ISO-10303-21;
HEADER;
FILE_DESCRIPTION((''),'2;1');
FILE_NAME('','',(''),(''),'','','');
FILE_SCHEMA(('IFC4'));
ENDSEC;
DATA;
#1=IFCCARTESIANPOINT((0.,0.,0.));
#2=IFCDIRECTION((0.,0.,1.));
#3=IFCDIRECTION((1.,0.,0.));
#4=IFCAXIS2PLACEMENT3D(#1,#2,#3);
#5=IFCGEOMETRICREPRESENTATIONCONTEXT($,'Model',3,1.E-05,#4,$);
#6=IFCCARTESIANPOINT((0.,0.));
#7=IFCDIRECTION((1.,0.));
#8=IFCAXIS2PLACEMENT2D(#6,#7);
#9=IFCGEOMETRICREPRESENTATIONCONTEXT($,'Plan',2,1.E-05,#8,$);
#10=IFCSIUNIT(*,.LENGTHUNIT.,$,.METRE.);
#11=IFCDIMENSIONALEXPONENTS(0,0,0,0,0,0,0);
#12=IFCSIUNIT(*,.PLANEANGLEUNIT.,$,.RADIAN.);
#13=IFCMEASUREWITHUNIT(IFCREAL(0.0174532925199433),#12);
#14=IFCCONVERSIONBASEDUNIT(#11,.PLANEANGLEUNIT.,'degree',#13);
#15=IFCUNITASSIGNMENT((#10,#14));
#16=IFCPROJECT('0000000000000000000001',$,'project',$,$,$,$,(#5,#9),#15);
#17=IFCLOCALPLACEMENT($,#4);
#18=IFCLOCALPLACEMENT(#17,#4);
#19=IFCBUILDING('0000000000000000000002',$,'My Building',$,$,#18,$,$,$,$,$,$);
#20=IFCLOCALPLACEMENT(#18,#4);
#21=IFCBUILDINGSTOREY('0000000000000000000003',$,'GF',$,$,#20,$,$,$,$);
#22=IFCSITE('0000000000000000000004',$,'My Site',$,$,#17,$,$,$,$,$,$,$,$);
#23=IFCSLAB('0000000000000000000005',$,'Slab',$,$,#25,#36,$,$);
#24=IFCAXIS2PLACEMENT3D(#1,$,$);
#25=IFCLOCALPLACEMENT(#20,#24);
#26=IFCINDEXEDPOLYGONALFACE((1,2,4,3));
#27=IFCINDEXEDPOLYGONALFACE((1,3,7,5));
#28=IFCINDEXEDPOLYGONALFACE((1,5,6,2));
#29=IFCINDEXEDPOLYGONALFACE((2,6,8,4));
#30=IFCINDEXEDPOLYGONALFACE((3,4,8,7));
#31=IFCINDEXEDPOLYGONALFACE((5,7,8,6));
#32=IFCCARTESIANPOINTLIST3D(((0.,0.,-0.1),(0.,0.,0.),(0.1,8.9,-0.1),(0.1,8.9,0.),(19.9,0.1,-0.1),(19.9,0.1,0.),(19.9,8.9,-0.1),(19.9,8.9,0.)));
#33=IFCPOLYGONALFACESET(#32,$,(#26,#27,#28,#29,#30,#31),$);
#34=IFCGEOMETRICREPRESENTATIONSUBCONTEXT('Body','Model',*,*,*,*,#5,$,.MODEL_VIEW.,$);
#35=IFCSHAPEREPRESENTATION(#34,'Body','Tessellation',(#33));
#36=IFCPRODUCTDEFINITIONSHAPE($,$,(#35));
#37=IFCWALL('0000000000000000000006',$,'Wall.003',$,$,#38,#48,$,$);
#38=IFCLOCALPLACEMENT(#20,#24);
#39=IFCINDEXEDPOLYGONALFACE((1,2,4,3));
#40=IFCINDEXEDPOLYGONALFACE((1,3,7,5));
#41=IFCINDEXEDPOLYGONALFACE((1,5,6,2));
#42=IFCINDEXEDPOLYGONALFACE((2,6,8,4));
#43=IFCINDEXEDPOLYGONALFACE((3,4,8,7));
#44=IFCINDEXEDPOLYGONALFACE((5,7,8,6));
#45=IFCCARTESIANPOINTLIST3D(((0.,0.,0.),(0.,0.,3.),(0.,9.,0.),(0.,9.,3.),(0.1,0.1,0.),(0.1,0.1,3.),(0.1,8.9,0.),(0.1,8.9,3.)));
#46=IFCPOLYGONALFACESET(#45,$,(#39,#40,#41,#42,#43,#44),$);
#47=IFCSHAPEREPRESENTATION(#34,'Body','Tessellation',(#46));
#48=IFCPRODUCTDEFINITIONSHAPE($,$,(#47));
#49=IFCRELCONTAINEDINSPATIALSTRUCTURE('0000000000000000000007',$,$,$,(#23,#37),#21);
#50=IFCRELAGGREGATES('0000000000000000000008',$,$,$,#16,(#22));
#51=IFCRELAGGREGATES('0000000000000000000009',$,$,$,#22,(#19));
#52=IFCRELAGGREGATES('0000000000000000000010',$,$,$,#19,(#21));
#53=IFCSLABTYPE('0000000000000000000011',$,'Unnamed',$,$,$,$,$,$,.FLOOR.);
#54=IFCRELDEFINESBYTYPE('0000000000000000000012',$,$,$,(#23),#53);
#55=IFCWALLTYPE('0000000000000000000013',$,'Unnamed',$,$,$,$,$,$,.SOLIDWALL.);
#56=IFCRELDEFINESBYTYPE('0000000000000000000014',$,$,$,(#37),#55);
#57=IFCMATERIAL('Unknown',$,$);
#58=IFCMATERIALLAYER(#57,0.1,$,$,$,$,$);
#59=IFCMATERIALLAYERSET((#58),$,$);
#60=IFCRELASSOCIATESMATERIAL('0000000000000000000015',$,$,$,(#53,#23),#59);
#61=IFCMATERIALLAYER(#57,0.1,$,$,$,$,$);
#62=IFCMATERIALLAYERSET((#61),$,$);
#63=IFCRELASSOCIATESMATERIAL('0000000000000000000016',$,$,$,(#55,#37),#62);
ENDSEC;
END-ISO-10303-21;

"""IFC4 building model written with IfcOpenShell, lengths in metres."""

from ifc_helpers import new_model, entity, si_unit, converted_unit, frame, origin_with_axes, origin_2d_with_axis, place, context, subcontext, project, spatial, line, indexed_curve, outline, extrude, material, layer, layer_set, layer_usage, type_object, element, save


model = new_model("IFC4")

# Units and contexts
model_context = context("Model", 3, precision=1e-05, world=origin_with_axes())
plan_context = context("Plan", 2, precision=1e-05, world=origin_2d_with_axis())
body_context_1 = subcontext(model_context, "Body", "Model", "MODEL_VIEW")
ifc_project = project(units=[si_unit("LENGTHUNIT", "METRE"), converted_unit("PLANEANGLEUNIT", "degree", entity("IfcReal", 0.0174532925199433), si_unit("PLANEANGLEUNIT", "RADIAN"), dimensions=[0, 0, 0, 0, 0, 0, 0])], contexts=[model_context, plan_context])

# Site, building, storey
site_placement = place(None, origin_with_axes())
site = spatial("IfcSite", under=ifc_project, at=site_placement, Name="My Site")
building_placement = place(site_placement, origin_with_axes())
building = spatial("IfcBuilding", under=site, at=building_placement, Name="My Building")
storey_placement = place(building_placement, origin_with_axes())
storey = spatial("IfcBuildingStorey", under=building, at=storey_placement, Name="GF")

# Slab
ifc_material = material(Name="Unknown")
ifc_layer_1 = layer(ifc_material, 0.1)
ifc_layer_set_1 = layer_set([ifc_layer_1])
ifc_layer_usage_1 = layer_usage(ifc_layer_set_1, "AXIS3", "POSITIVE", -0.1)
slab_type = type_object("IfcSlabType", Name="Unnamed", PredefinedType="FLOOR", material=ifc_layer_set_1)
slab_placement = place(storey_placement, frame((0.1, 8.9, 0.0), z_axis=(0.0, 0.0, 1.0), x_axis=(1.0, 0.0, 0.0)))
element("IfcSlab", 1, at=slab_placement, inside=storey, type_object=slab_type, material=ifc_layer_usage_1, Name="Slab", context=body_context_1, shape_type="SweptSolid", body=[
    extrude(outline(indexed_curve([(0.0, 0.0), (19.8, 0.0), (19.8, -8.8), (-0.1, -8.9), (0.0, 0.0)])), frame((0.0, 0.0, -0.1), z_axis=(0.0, 0.0, 1.0), x_axis=(1.0, 0.0, 0.0)), (0.0, 0.0, 1.0), 0.1),
])

# Shared definitions
ifc_layer_2 = layer(ifc_material, 0.1)
ifc_layer_set_2 = layer_set([ifc_layer_2])
wall_type = type_object("IfcWallType", Name="Unnamed", PredefinedType="SOLIDWALL", material=ifc_layer_set_2)

# Wall
ifc_layer_usage_2 = layer_usage(ifc_layer_set_2, "AXIS2", "POSITIVE", 0.0)
wall_1_placement = place(storey_placement, frame((0.0, 9.0, 0.0), z_axis=(0.0, 0.0, 1.0), x_axis=(0.0, -1.0, 0.0)))
element("IfcWall", 2, at=wall_1_placement, inside=storey, type_object=wall_type, material=ifc_layer_usage_2, Name="Wall.003", context=body_context_1, shape_type="SweptSolid", body=[
    extrude(outline(indexed_curve([(0.0, 0.0), (0.1, 0.1), (8.9, 0.1), (9.0, 0.0)], segments=[line(1, 2, 3, 4, 1)])), origin_with_axes(), (0.0, 0.0, 1.0), 3.0),
])

save(model, "model.ifc")
